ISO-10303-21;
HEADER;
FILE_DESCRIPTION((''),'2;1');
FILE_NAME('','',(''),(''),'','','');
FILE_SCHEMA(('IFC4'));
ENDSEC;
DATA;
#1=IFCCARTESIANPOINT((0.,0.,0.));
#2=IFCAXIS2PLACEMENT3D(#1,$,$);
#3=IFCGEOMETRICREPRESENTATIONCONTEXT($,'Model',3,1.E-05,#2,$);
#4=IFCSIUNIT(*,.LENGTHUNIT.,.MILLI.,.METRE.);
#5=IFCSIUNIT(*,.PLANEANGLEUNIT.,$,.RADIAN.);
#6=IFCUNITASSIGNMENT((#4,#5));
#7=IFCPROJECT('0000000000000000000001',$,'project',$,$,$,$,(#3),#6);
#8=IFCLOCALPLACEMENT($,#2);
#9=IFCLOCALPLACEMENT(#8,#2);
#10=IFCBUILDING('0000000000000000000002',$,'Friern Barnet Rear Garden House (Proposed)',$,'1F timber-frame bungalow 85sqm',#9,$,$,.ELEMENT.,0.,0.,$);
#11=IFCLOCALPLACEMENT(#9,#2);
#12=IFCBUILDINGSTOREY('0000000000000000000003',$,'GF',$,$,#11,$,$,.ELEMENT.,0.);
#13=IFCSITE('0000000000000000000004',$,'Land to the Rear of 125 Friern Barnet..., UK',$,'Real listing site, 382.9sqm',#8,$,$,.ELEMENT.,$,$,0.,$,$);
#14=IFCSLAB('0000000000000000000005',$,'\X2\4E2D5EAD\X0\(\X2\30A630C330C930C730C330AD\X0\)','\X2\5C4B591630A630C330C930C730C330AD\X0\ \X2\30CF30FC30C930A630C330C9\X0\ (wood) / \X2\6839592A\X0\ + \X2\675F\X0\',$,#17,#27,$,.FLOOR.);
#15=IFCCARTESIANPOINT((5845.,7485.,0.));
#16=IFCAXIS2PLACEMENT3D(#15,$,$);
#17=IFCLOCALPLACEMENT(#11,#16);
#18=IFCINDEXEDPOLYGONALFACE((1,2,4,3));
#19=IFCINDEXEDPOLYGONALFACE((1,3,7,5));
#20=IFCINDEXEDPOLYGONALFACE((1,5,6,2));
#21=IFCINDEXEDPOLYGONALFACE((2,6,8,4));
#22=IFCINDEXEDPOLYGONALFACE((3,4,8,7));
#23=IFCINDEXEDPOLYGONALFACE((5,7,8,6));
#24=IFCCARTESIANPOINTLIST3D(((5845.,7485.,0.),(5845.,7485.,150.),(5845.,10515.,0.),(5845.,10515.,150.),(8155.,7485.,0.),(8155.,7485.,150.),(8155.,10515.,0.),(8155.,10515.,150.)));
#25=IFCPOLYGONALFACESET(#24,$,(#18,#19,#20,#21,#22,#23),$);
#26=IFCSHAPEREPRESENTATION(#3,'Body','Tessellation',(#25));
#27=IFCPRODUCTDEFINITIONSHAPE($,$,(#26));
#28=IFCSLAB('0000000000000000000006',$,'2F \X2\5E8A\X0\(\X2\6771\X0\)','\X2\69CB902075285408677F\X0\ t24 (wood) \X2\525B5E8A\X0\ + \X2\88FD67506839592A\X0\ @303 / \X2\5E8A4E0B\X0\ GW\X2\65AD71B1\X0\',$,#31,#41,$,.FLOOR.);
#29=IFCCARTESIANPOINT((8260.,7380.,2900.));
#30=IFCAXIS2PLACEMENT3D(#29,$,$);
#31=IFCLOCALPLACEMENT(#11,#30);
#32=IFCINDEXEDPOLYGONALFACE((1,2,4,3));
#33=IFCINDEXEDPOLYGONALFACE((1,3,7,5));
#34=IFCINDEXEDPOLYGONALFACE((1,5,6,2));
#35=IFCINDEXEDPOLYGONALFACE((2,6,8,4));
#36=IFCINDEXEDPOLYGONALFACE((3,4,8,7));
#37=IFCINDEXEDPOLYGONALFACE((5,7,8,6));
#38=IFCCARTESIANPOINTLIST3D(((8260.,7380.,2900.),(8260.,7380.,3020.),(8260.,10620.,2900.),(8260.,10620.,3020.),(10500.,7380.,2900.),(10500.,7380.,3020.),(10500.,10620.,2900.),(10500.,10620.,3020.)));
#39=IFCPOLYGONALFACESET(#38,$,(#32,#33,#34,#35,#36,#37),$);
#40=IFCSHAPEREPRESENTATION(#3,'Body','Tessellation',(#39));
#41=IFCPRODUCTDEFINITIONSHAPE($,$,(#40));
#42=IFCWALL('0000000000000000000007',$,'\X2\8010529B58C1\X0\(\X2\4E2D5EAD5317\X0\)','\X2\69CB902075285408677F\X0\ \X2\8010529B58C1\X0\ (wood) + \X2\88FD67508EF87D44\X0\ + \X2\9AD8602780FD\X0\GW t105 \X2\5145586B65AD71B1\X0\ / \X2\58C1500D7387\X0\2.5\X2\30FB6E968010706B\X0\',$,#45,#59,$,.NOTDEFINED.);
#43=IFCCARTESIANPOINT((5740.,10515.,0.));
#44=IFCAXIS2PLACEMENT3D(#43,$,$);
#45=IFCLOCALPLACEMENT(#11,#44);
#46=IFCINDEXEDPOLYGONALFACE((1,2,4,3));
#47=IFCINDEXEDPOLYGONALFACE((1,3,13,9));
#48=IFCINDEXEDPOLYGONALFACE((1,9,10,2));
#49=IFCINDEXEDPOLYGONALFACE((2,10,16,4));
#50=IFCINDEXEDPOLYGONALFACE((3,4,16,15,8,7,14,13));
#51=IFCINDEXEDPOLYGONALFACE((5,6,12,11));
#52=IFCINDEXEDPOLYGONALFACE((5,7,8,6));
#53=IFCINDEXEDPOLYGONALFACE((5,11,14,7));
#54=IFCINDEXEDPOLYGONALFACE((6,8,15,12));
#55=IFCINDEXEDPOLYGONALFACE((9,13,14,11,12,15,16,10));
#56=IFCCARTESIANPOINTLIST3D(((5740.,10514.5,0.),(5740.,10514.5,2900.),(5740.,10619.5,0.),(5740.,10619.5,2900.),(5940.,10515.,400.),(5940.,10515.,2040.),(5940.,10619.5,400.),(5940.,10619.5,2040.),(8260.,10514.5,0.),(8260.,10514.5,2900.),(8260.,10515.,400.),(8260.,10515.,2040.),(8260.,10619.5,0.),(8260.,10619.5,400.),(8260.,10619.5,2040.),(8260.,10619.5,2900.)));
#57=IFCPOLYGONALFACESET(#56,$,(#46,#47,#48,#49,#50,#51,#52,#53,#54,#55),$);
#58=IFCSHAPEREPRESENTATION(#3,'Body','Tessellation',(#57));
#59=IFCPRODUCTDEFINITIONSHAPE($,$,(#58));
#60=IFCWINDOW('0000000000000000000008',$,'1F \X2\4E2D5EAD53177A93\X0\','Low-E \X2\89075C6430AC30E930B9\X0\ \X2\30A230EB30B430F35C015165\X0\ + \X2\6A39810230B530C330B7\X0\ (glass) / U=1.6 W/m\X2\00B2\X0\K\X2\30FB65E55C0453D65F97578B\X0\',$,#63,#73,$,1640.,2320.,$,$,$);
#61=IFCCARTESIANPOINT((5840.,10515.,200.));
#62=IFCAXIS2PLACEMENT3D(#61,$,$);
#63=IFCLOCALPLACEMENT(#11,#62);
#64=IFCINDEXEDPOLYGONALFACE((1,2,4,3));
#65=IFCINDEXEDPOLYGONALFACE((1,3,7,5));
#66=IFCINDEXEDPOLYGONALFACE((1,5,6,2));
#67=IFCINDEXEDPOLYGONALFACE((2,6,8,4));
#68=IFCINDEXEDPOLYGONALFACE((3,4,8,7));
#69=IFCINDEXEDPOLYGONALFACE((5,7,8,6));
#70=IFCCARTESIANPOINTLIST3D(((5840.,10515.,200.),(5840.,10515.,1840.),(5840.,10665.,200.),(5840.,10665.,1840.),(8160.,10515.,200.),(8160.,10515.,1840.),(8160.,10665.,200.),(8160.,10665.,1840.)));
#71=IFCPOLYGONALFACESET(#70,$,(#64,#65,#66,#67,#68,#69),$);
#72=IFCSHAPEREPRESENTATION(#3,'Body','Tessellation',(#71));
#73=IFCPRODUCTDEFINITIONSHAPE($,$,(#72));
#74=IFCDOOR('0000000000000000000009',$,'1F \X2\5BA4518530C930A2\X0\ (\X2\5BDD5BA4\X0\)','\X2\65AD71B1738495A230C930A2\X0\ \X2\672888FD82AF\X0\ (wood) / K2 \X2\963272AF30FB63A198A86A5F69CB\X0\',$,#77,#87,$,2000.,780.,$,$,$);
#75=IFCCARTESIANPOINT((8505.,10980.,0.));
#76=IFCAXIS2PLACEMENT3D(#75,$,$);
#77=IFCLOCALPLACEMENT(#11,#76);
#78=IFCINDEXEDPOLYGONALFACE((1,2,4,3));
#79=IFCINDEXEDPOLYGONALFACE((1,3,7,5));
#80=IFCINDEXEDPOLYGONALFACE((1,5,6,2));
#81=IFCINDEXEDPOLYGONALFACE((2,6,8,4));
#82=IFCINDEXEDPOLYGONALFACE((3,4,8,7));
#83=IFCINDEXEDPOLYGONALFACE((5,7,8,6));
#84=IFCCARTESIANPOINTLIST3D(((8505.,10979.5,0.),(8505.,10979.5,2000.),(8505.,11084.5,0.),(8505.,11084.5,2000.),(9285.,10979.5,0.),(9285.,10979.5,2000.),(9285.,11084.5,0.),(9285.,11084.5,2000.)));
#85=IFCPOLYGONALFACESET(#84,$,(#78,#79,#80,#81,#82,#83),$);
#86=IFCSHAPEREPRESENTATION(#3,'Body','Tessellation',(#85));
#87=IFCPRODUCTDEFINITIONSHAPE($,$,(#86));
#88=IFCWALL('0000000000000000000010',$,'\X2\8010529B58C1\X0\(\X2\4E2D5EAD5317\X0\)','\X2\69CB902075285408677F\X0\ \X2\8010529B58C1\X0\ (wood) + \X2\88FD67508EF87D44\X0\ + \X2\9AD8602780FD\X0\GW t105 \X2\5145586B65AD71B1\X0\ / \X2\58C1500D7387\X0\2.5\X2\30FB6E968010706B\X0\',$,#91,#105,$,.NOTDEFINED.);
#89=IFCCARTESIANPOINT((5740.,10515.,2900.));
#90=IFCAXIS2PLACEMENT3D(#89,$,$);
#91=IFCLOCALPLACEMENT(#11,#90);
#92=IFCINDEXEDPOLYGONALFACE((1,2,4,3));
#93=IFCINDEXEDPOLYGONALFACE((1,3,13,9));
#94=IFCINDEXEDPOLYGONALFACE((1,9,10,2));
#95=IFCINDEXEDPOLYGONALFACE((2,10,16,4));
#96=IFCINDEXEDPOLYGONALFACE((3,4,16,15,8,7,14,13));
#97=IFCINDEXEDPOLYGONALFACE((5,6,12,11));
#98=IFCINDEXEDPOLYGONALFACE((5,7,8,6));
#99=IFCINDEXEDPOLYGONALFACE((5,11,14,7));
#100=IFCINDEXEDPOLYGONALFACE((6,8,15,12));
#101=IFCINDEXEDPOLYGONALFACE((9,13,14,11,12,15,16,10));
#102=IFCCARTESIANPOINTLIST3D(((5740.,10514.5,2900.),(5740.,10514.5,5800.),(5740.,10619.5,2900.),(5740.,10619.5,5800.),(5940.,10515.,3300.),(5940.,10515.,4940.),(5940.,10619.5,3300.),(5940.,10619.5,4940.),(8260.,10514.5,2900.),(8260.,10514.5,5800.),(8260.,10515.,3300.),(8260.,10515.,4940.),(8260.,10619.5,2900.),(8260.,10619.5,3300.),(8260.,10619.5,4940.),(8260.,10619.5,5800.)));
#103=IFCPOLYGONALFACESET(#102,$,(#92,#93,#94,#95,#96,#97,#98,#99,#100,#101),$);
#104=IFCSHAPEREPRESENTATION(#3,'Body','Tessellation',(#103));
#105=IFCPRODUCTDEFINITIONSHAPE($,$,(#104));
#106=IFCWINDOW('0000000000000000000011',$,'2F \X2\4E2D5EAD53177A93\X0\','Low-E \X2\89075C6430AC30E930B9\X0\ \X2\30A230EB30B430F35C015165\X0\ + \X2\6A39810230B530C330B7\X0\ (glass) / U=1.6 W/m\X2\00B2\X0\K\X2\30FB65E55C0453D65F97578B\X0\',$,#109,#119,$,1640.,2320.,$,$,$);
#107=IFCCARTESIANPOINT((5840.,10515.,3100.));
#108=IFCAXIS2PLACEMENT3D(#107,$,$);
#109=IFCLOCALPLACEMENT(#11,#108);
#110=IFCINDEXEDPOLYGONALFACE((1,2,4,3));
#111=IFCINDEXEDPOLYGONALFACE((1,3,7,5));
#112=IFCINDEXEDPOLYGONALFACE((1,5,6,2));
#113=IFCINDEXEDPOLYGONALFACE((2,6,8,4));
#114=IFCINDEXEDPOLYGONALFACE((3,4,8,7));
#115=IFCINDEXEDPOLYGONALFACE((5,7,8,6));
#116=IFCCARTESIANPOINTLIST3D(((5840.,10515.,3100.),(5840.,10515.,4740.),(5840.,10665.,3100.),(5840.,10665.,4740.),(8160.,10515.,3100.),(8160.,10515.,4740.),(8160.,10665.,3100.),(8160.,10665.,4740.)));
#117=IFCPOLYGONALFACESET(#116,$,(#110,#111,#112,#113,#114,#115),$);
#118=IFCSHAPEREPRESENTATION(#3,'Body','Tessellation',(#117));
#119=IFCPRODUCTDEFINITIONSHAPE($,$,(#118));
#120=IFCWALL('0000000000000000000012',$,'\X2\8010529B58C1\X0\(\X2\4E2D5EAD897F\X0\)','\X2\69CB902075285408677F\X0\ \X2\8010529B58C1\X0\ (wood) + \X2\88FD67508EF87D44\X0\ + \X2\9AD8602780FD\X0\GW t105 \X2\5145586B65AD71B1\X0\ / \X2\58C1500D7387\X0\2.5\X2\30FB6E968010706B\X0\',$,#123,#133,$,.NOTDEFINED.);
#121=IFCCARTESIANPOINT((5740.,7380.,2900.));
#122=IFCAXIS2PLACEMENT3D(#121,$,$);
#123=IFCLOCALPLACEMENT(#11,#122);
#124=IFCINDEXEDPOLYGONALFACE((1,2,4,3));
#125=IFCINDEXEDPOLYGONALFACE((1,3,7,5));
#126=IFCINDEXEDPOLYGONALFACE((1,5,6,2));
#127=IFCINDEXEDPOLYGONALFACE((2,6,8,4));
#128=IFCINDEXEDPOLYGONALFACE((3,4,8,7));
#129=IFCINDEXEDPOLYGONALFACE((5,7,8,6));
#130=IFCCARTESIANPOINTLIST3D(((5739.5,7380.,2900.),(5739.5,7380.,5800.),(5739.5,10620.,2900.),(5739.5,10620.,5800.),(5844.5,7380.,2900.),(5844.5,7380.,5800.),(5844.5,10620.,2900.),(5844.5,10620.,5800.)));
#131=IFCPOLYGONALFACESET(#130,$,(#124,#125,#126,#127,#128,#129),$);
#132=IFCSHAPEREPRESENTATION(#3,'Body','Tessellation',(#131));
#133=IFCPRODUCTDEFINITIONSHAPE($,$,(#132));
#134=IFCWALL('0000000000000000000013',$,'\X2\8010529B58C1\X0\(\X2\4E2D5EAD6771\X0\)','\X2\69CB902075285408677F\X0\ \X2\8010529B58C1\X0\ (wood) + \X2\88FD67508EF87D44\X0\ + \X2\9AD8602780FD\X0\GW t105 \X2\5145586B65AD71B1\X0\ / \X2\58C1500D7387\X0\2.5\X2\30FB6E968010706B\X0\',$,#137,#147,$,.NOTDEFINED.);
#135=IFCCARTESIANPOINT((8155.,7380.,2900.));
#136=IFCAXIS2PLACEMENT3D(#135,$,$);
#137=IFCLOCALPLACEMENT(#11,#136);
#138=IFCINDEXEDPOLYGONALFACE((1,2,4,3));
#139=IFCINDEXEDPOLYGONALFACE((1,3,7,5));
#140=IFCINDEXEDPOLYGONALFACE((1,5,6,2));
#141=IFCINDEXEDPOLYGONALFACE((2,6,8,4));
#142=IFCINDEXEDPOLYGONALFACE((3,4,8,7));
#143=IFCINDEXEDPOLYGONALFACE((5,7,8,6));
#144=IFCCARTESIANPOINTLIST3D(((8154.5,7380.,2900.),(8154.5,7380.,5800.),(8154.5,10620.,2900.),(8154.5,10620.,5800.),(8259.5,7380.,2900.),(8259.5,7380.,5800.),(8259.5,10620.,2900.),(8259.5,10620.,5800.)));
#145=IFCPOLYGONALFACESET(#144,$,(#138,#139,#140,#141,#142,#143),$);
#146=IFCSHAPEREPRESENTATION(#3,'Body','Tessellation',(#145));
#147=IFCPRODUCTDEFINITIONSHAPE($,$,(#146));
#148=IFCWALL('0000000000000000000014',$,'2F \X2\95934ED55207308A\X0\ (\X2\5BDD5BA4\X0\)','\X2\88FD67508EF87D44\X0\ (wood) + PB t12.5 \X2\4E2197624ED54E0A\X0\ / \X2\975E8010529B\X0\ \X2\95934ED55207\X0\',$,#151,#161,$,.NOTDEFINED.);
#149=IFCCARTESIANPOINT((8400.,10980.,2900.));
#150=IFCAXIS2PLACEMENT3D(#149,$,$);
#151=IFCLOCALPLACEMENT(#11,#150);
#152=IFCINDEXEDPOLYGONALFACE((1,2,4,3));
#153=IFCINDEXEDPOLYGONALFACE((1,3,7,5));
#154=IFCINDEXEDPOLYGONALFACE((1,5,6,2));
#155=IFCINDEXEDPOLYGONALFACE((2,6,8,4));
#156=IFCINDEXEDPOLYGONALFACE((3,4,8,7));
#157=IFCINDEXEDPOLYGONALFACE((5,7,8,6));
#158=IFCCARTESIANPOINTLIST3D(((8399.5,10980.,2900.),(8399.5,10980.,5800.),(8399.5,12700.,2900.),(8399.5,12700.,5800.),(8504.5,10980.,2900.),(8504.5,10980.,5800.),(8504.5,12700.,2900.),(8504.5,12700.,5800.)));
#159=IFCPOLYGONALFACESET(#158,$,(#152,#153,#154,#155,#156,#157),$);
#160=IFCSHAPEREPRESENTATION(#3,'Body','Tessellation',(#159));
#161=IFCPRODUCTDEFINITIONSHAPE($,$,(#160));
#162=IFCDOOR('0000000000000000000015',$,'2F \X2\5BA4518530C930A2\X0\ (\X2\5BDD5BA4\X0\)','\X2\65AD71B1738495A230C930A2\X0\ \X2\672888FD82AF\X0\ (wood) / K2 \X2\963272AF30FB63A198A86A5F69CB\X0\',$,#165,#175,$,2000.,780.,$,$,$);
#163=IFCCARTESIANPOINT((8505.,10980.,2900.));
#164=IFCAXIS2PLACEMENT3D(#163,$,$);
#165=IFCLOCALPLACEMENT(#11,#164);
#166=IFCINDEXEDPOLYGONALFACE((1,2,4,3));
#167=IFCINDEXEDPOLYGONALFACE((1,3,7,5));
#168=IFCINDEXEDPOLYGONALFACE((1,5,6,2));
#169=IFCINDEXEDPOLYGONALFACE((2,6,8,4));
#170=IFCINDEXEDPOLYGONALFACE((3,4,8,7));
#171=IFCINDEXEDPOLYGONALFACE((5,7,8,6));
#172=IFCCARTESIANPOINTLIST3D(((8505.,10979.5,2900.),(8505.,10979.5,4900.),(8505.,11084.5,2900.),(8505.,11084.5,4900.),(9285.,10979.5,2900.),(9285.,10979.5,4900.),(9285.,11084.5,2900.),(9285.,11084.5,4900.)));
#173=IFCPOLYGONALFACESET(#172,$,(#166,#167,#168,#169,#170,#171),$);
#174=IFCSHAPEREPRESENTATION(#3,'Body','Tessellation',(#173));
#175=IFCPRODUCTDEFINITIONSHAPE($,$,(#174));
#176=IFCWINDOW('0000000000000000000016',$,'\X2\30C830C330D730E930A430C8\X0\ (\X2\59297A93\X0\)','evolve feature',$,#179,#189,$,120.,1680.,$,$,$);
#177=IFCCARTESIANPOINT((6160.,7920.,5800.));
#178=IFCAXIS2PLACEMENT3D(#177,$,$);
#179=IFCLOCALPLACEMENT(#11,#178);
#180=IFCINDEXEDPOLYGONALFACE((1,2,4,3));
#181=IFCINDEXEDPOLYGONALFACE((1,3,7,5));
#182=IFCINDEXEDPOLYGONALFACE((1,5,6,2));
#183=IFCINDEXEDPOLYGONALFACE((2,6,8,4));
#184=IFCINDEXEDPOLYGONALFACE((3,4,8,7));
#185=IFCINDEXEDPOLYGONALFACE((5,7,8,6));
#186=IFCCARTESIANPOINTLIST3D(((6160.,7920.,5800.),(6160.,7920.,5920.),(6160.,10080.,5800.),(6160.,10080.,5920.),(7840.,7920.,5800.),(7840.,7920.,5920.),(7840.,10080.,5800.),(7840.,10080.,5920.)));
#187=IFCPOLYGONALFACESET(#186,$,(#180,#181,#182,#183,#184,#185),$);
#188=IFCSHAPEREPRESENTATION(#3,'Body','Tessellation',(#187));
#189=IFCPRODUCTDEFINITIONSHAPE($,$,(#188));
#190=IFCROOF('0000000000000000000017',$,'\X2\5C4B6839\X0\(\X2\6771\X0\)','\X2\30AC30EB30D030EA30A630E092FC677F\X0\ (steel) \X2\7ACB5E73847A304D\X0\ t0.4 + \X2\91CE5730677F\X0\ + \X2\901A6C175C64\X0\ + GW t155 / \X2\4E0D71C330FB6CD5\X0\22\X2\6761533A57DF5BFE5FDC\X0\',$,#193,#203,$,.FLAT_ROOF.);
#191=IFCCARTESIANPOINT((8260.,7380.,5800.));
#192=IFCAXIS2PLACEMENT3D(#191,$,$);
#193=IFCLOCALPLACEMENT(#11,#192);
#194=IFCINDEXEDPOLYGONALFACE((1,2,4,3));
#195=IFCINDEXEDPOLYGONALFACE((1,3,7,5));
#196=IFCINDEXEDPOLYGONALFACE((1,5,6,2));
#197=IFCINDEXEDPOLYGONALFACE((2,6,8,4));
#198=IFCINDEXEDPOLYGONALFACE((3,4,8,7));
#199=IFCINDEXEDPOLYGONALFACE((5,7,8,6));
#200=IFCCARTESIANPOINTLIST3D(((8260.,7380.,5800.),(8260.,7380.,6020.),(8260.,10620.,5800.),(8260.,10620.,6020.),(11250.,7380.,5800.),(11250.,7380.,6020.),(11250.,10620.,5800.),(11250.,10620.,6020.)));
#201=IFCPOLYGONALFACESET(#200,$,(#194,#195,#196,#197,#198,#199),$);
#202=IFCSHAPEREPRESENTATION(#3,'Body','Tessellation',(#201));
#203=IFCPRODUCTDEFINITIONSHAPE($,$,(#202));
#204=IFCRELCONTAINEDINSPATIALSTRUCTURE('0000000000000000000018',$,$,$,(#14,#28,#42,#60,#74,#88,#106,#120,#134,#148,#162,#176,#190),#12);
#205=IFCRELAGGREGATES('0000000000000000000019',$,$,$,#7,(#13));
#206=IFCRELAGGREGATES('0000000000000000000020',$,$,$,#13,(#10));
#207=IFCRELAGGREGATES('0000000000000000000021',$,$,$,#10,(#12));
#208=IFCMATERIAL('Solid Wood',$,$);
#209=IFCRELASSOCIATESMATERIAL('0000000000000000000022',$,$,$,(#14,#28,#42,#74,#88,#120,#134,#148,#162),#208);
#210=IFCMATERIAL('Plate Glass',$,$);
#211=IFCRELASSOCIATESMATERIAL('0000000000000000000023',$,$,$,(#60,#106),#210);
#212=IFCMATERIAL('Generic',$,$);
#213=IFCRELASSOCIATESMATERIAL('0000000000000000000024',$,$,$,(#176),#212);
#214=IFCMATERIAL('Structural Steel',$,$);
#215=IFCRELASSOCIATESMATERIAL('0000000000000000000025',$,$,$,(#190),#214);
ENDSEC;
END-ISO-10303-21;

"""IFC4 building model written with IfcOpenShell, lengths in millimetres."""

from ifc_helpers import new_model, si_unit, frame, frame_2d, origin, place, context, project, spatial, rectangle, extrude, material, element, fill, save


model = new_model("IFC4")

# Units and contexts
model_context = context("Model", 3, precision=1e-05, world=origin())
ifc_project = project(units=[si_unit("LENGTHUNIT", "METRE", prefix="MILLI"), si_unit("PLANEANGLEUNIT", "RADIAN")], contexts=[model_context])

# Site, building, storey
site_placement = place(None, origin())
site = spatial("IfcSite", under=ifc_project, at=site_placement, Name="Land to the Rear of 125 Friern Barnet..., UK", ObjectType="Real listing site, 382.9sqm", CompositionType="ELEMENT", RefElevation=0.0)
building_placement = place(site_placement, origin())
building = spatial("IfcBuilding", under=site, at=building_placement, Name="Friern Barnet Rear Garden House (Proposed)", ObjectType="1F timber-frame bungalow 85sqm", CompositionType="ELEMENT", ElevationOfRefHeight=0.0, ElevationOfTerrain=0.0)
storey_placement = place(building_placement, origin())
storey = spatial("IfcBuildingStorey", under=building, at=storey_placement, Name="GF", CompositionType="ELEMENT", Elevation=0.0)

# Slabs
ifc_material_1 = material(Name="Solid Wood")
slab_1_placement = place(storey_placement, frame((5845.0, 7485.0, 0.0)))
element("IfcSlab", 1, at=slab_1_placement, inside=storey, material=ifc_material_1, Name="中庭(ウッドデッキ)", Description="屋外ウッドデッキ ハードウッド (wood) / 根太 + 束", PredefinedType="FLOOR", context=model_context, shape_type="SweptSolid", body=[
    extrude(rectangle(XDim=2310.0, YDim=3030.0, at=frame_2d((1155.0, 1515.0))), frame((5845.0, 7485.0, 0.0)), (0.0, 0.0, 1.0), 150.0),
])
slab_2_placement = place(storey_placement, frame((8260.0, 7380.0, 2900.0)))
element("IfcSlab", 2, at=slab_2_placement, inside=storey, material=ifc_material_1, Name="2F 床(東)", Description="構造用合板 t24 (wood) 剛床 + 製材根太 @303 / 床下 GW断熱", PredefinedType="FLOOR", context=model_context, shape_type="SweptSolid", body=[
    extrude(rectangle(XDim=2240.0, YDim=3240.0, at=frame_2d((1120.0, 1620.0))), frame((8260.0, 7380.0, 2900.0)), (0.0, 0.0, 1.0), 120.0),
])

# Wall, opening, window
wall_1_placement = place(storey_placement, frame((5740.0, 10515.0, 0.0)))
wall_1 = element("IfcWall", 3, at=wall_1_placement, inside=storey, material=ifc_material_1, Name="耐力壁(中庭北)", Description="構造用合板 耐力壁 (wood) + 製材軸組 + 高性能GW t105 充填断熱 / 壁倍率2.5・準耐火", PredefinedType="NOTDEFINED", context=model_context, shape_type="SweptSolid", body=[
    extrude(rectangle(XDim=2520.0, YDim=105.0, at=frame_2d((1260.0, 52.0))), frame((5740.0, 10515.0, 0.0)), (0.0, 0.0, 1.0), 2900.0),
])
opening_1_placement = place(storey_placement, frame((5840.0, 10515.0, 200.0)))
opening_1 = element("IfcOpeningElement", 4, at=opening_1_placement, cuts=wall_1, PredefinedType="NOTDEFINED", context=model_context, shape_type="SweptSolid", body=[
    extrude(rectangle(XDim=2320.0, YDim=150.0, at=frame_2d((1160.0, 75.0))), frame((5840.0, 10515.0, 200.0)), (0.0, 0.0, 1.0), 1640.0),
])
ifc_material_2 = material(Name="Plate Glass")
window_1_placement = place(storey_placement, frame((5840.0, 10515.0, 200.0)))
window_1 = element("IfcWindow", 5, at=window_1_placement, inside=storey, material=ifc_material_2, Name="1F 中庭北窓", Description="Low-E 複層ガラス アルゴン封入 + 樹脂サッシ (glass) / U=1.6 W/m²K・日射取得型", OverallHeight=1640.0, OverallWidth=2320.0, context=model_context, shape_type="SweptSolid", body=[
    extrude(rectangle(XDim=2320.0, YDim=150.0, at=frame_2d((1160.0, 75.0))), frame((5840.0, 10515.0, 200.0)), (0.0, 0.0, 1.0), 1640.0),
])
fill(opening_1, window_1)

# Door
door_1_placement = place(storey_placement, frame((8505.0, 10980.0, 0.0)))
element("IfcDoor", 6, at=door_1_placement, inside=storey, material=ifc_material_1, Name="1F 室内ドア (寝室)", Description="断熱玄関ドア 木製芯 (wood) / K2 防犯・採風機構", OverallHeight=2000.0, OverallWidth=780.0, context=model_context, shape_type="SweptSolid", body=[
    extrude(rectangle(XDim=780.0, YDim=105.0, at=frame_2d((390.0, 52.0))), frame((8505.0, 10980.0, 0.0)), (0.0, 0.0, 1.0), 2000.0),
])

# Wall, opening, window
wall_2_placement = place(storey_placement, frame((5740.0, 10515.0, 2900.0)))
wall_2 = element("IfcWall", 7, at=wall_2_placement, inside=storey, material=ifc_material_1, Name="耐力壁(中庭北)", Description="構造用合板 耐力壁 (wood) + 製材軸組 + 高性能GW t105 充填断熱 / 壁倍率2.5・準耐火", PredefinedType="NOTDEFINED", context=model_context, shape_type="SweptSolid", body=[
    extrude(rectangle(XDim=2520.0, YDim=105.0, at=frame_2d((1260.0, 52.0))), frame((5740.0, 10515.0, 2900.0)), (0.0, 0.0, 1.0), 2900.0),
])
opening_2_placement = place(storey_placement, frame((5840.0, 10515.0, 3100.0)))
opening_2 = element("IfcOpeningElement", 8, at=opening_2_placement, cuts=wall_2, PredefinedType="NOTDEFINED", context=model_context, shape_type="SweptSolid", body=[
    extrude(rectangle(XDim=2320.0, YDim=150.0, at=frame_2d((1160.0, 75.0))), frame((5840.0, 10515.0, 3100.0)), (0.0, 0.0, 1.0), 1640.0),
])
window_2_placement = place(storey_placement, frame((5840.0, 10515.0, 3100.0)))
window_2 = element("IfcWindow", 9, at=window_2_placement, inside=storey, material=ifc_material_2, Name="2F 中庭北窓", Description="Low-E 複層ガラス アルゴン封入 + 樹脂サッシ (glass) / U=1.6 W/m²K・日射取得型", OverallHeight=1640.0, OverallWidth=2320.0, context=model_context, shape_type="SweptSolid", body=[
    extrude(rectangle(XDim=2320.0, YDim=150.0, at=frame_2d((1160.0, 75.0))), frame((5840.0, 10515.0, 3100.0)), (0.0, 0.0, 1.0), 1640.0),
])
fill(opening_2, window_2)

# Walls
wall_3_placement = place(storey_placement, frame((5740.0, 7380.0, 2900.0)))
element("IfcWall", 10, at=wall_3_placement, inside=storey, material=ifc_material_1, Name="耐力壁(中庭西)", Description="構造用合板 耐力壁 (wood) + 製材軸組 + 高性能GW t105 充填断熱 / 壁倍率2.5・準耐火", PredefinedType="NOTDEFINED", context=model_context, shape_type="SweptSolid", body=[
    extrude(rectangle(XDim=105.0, YDim=3240.0, at=frame_2d((52.0, 1620.0))), frame((5740.0, 7380.0, 2900.0)), (0.0, 0.0, 1.0), 2900.0),
])
wall_4_placement = place(storey_placement, frame((8155.0, 7380.0, 2900.0)))
element("IfcWall", 11, at=wall_4_placement, inside=storey, material=ifc_material_1, Name="耐力壁(中庭東)", Description="構造用合板 耐力壁 (wood) + 製材軸組 + 高性能GW t105 充填断熱 / 壁倍率2.5・準耐火", PredefinedType="NOTDEFINED", context=model_context, shape_type="SweptSolid", body=[
    extrude(rectangle(XDim=105.0, YDim=3240.0, at=frame_2d((52.0, 1620.0))), frame((8155.0, 7380.0, 2900.0)), (0.0, 0.0, 1.0), 2900.0),
])
wall_5_placement = place(storey_placement, frame((8400.0, 10980.0, 2900.0)))
element("IfcWall", 12, at=wall_5_placement, inside=storey, material=ifc_material_1, Name="2F 間仕切り (寝室)", Description="製材軸組 (wood) + PB t12.5 両面仕上 / 非耐力 間仕切", PredefinedType="NOTDEFINED", context=model_context, shape_type="SweptSolid", body=[
    extrude(rectangle(XDim=105.0, YDim=1720.0, at=frame_2d((52.0, 860.0))), frame((8400.0, 10980.0, 2900.0)), (0.0, 0.0, 1.0), 2900.0),
])

# Door
door_2_placement = place(storey_placement, frame((8505.0, 10980.0, 2900.0)))
element("IfcDoor", 13, at=door_2_placement, inside=storey, material=ifc_material_1, Name="2F 室内ドア (寝室)", Description="断熱玄関ドア 木製芯 (wood) / K2 防犯・採風機構", OverallHeight=2000.0, OverallWidth=780.0, context=model_context, shape_type="SweptSolid", body=[
    extrude(rectangle(XDim=780.0, YDim=105.0, at=frame_2d((390.0, 52.0))), frame((8505.0, 10980.0, 2900.0)), (0.0, 0.0, 1.0), 2000.0),
])

# Window
ifc_material_3 = material(Name="Generic")
window_3_placement = place(storey_placement, frame((6160.0, 7920.0, 5800.0)))
element("IfcWindow", 14, at=window_3_placement, inside=storey, material=ifc_material_3, Name="トップライト (天窓)", Description="evolve feature", OverallHeight=120.0, OverallWidth=1680.0, context=model_context, shape_type="SweptSolid", body=[
    extrude(rectangle(XDim=1680.0, YDim=2160.0, at=frame_2d((840.0, 1080.0))), frame((6160.0, 7920.0, 5800.0)), (0.0, 0.0, 1.0), 120.0),
])

# Roof
ifc_material_4 = material(Name="Structural Steel")
roof_placement = place(storey_placement, frame((8260.0, 7380.0, 5800.0)))
element("IfcRoof", 15, at=roof_placement, inside=storey, material=ifc_material_4, Name="屋根(東)", Description="ガルバリウム鋼板 (steel) 立平葺き t0.4 + 野地板 + 通気層 + GW t155 / 不燃・法22条区域対応", PredefinedType="FLAT_ROOF", context=model_context, shape_type="SweptSolid", body=[
    extrude(rectangle(XDim=2990.0, YDim=3240.0, at=frame_2d((1495.0, 1620.0))), frame((8260.0, 7380.0, 5800.0)), (0.0, 0.0, 1.0), 220.0),
])

save(model, "model.ifc")
